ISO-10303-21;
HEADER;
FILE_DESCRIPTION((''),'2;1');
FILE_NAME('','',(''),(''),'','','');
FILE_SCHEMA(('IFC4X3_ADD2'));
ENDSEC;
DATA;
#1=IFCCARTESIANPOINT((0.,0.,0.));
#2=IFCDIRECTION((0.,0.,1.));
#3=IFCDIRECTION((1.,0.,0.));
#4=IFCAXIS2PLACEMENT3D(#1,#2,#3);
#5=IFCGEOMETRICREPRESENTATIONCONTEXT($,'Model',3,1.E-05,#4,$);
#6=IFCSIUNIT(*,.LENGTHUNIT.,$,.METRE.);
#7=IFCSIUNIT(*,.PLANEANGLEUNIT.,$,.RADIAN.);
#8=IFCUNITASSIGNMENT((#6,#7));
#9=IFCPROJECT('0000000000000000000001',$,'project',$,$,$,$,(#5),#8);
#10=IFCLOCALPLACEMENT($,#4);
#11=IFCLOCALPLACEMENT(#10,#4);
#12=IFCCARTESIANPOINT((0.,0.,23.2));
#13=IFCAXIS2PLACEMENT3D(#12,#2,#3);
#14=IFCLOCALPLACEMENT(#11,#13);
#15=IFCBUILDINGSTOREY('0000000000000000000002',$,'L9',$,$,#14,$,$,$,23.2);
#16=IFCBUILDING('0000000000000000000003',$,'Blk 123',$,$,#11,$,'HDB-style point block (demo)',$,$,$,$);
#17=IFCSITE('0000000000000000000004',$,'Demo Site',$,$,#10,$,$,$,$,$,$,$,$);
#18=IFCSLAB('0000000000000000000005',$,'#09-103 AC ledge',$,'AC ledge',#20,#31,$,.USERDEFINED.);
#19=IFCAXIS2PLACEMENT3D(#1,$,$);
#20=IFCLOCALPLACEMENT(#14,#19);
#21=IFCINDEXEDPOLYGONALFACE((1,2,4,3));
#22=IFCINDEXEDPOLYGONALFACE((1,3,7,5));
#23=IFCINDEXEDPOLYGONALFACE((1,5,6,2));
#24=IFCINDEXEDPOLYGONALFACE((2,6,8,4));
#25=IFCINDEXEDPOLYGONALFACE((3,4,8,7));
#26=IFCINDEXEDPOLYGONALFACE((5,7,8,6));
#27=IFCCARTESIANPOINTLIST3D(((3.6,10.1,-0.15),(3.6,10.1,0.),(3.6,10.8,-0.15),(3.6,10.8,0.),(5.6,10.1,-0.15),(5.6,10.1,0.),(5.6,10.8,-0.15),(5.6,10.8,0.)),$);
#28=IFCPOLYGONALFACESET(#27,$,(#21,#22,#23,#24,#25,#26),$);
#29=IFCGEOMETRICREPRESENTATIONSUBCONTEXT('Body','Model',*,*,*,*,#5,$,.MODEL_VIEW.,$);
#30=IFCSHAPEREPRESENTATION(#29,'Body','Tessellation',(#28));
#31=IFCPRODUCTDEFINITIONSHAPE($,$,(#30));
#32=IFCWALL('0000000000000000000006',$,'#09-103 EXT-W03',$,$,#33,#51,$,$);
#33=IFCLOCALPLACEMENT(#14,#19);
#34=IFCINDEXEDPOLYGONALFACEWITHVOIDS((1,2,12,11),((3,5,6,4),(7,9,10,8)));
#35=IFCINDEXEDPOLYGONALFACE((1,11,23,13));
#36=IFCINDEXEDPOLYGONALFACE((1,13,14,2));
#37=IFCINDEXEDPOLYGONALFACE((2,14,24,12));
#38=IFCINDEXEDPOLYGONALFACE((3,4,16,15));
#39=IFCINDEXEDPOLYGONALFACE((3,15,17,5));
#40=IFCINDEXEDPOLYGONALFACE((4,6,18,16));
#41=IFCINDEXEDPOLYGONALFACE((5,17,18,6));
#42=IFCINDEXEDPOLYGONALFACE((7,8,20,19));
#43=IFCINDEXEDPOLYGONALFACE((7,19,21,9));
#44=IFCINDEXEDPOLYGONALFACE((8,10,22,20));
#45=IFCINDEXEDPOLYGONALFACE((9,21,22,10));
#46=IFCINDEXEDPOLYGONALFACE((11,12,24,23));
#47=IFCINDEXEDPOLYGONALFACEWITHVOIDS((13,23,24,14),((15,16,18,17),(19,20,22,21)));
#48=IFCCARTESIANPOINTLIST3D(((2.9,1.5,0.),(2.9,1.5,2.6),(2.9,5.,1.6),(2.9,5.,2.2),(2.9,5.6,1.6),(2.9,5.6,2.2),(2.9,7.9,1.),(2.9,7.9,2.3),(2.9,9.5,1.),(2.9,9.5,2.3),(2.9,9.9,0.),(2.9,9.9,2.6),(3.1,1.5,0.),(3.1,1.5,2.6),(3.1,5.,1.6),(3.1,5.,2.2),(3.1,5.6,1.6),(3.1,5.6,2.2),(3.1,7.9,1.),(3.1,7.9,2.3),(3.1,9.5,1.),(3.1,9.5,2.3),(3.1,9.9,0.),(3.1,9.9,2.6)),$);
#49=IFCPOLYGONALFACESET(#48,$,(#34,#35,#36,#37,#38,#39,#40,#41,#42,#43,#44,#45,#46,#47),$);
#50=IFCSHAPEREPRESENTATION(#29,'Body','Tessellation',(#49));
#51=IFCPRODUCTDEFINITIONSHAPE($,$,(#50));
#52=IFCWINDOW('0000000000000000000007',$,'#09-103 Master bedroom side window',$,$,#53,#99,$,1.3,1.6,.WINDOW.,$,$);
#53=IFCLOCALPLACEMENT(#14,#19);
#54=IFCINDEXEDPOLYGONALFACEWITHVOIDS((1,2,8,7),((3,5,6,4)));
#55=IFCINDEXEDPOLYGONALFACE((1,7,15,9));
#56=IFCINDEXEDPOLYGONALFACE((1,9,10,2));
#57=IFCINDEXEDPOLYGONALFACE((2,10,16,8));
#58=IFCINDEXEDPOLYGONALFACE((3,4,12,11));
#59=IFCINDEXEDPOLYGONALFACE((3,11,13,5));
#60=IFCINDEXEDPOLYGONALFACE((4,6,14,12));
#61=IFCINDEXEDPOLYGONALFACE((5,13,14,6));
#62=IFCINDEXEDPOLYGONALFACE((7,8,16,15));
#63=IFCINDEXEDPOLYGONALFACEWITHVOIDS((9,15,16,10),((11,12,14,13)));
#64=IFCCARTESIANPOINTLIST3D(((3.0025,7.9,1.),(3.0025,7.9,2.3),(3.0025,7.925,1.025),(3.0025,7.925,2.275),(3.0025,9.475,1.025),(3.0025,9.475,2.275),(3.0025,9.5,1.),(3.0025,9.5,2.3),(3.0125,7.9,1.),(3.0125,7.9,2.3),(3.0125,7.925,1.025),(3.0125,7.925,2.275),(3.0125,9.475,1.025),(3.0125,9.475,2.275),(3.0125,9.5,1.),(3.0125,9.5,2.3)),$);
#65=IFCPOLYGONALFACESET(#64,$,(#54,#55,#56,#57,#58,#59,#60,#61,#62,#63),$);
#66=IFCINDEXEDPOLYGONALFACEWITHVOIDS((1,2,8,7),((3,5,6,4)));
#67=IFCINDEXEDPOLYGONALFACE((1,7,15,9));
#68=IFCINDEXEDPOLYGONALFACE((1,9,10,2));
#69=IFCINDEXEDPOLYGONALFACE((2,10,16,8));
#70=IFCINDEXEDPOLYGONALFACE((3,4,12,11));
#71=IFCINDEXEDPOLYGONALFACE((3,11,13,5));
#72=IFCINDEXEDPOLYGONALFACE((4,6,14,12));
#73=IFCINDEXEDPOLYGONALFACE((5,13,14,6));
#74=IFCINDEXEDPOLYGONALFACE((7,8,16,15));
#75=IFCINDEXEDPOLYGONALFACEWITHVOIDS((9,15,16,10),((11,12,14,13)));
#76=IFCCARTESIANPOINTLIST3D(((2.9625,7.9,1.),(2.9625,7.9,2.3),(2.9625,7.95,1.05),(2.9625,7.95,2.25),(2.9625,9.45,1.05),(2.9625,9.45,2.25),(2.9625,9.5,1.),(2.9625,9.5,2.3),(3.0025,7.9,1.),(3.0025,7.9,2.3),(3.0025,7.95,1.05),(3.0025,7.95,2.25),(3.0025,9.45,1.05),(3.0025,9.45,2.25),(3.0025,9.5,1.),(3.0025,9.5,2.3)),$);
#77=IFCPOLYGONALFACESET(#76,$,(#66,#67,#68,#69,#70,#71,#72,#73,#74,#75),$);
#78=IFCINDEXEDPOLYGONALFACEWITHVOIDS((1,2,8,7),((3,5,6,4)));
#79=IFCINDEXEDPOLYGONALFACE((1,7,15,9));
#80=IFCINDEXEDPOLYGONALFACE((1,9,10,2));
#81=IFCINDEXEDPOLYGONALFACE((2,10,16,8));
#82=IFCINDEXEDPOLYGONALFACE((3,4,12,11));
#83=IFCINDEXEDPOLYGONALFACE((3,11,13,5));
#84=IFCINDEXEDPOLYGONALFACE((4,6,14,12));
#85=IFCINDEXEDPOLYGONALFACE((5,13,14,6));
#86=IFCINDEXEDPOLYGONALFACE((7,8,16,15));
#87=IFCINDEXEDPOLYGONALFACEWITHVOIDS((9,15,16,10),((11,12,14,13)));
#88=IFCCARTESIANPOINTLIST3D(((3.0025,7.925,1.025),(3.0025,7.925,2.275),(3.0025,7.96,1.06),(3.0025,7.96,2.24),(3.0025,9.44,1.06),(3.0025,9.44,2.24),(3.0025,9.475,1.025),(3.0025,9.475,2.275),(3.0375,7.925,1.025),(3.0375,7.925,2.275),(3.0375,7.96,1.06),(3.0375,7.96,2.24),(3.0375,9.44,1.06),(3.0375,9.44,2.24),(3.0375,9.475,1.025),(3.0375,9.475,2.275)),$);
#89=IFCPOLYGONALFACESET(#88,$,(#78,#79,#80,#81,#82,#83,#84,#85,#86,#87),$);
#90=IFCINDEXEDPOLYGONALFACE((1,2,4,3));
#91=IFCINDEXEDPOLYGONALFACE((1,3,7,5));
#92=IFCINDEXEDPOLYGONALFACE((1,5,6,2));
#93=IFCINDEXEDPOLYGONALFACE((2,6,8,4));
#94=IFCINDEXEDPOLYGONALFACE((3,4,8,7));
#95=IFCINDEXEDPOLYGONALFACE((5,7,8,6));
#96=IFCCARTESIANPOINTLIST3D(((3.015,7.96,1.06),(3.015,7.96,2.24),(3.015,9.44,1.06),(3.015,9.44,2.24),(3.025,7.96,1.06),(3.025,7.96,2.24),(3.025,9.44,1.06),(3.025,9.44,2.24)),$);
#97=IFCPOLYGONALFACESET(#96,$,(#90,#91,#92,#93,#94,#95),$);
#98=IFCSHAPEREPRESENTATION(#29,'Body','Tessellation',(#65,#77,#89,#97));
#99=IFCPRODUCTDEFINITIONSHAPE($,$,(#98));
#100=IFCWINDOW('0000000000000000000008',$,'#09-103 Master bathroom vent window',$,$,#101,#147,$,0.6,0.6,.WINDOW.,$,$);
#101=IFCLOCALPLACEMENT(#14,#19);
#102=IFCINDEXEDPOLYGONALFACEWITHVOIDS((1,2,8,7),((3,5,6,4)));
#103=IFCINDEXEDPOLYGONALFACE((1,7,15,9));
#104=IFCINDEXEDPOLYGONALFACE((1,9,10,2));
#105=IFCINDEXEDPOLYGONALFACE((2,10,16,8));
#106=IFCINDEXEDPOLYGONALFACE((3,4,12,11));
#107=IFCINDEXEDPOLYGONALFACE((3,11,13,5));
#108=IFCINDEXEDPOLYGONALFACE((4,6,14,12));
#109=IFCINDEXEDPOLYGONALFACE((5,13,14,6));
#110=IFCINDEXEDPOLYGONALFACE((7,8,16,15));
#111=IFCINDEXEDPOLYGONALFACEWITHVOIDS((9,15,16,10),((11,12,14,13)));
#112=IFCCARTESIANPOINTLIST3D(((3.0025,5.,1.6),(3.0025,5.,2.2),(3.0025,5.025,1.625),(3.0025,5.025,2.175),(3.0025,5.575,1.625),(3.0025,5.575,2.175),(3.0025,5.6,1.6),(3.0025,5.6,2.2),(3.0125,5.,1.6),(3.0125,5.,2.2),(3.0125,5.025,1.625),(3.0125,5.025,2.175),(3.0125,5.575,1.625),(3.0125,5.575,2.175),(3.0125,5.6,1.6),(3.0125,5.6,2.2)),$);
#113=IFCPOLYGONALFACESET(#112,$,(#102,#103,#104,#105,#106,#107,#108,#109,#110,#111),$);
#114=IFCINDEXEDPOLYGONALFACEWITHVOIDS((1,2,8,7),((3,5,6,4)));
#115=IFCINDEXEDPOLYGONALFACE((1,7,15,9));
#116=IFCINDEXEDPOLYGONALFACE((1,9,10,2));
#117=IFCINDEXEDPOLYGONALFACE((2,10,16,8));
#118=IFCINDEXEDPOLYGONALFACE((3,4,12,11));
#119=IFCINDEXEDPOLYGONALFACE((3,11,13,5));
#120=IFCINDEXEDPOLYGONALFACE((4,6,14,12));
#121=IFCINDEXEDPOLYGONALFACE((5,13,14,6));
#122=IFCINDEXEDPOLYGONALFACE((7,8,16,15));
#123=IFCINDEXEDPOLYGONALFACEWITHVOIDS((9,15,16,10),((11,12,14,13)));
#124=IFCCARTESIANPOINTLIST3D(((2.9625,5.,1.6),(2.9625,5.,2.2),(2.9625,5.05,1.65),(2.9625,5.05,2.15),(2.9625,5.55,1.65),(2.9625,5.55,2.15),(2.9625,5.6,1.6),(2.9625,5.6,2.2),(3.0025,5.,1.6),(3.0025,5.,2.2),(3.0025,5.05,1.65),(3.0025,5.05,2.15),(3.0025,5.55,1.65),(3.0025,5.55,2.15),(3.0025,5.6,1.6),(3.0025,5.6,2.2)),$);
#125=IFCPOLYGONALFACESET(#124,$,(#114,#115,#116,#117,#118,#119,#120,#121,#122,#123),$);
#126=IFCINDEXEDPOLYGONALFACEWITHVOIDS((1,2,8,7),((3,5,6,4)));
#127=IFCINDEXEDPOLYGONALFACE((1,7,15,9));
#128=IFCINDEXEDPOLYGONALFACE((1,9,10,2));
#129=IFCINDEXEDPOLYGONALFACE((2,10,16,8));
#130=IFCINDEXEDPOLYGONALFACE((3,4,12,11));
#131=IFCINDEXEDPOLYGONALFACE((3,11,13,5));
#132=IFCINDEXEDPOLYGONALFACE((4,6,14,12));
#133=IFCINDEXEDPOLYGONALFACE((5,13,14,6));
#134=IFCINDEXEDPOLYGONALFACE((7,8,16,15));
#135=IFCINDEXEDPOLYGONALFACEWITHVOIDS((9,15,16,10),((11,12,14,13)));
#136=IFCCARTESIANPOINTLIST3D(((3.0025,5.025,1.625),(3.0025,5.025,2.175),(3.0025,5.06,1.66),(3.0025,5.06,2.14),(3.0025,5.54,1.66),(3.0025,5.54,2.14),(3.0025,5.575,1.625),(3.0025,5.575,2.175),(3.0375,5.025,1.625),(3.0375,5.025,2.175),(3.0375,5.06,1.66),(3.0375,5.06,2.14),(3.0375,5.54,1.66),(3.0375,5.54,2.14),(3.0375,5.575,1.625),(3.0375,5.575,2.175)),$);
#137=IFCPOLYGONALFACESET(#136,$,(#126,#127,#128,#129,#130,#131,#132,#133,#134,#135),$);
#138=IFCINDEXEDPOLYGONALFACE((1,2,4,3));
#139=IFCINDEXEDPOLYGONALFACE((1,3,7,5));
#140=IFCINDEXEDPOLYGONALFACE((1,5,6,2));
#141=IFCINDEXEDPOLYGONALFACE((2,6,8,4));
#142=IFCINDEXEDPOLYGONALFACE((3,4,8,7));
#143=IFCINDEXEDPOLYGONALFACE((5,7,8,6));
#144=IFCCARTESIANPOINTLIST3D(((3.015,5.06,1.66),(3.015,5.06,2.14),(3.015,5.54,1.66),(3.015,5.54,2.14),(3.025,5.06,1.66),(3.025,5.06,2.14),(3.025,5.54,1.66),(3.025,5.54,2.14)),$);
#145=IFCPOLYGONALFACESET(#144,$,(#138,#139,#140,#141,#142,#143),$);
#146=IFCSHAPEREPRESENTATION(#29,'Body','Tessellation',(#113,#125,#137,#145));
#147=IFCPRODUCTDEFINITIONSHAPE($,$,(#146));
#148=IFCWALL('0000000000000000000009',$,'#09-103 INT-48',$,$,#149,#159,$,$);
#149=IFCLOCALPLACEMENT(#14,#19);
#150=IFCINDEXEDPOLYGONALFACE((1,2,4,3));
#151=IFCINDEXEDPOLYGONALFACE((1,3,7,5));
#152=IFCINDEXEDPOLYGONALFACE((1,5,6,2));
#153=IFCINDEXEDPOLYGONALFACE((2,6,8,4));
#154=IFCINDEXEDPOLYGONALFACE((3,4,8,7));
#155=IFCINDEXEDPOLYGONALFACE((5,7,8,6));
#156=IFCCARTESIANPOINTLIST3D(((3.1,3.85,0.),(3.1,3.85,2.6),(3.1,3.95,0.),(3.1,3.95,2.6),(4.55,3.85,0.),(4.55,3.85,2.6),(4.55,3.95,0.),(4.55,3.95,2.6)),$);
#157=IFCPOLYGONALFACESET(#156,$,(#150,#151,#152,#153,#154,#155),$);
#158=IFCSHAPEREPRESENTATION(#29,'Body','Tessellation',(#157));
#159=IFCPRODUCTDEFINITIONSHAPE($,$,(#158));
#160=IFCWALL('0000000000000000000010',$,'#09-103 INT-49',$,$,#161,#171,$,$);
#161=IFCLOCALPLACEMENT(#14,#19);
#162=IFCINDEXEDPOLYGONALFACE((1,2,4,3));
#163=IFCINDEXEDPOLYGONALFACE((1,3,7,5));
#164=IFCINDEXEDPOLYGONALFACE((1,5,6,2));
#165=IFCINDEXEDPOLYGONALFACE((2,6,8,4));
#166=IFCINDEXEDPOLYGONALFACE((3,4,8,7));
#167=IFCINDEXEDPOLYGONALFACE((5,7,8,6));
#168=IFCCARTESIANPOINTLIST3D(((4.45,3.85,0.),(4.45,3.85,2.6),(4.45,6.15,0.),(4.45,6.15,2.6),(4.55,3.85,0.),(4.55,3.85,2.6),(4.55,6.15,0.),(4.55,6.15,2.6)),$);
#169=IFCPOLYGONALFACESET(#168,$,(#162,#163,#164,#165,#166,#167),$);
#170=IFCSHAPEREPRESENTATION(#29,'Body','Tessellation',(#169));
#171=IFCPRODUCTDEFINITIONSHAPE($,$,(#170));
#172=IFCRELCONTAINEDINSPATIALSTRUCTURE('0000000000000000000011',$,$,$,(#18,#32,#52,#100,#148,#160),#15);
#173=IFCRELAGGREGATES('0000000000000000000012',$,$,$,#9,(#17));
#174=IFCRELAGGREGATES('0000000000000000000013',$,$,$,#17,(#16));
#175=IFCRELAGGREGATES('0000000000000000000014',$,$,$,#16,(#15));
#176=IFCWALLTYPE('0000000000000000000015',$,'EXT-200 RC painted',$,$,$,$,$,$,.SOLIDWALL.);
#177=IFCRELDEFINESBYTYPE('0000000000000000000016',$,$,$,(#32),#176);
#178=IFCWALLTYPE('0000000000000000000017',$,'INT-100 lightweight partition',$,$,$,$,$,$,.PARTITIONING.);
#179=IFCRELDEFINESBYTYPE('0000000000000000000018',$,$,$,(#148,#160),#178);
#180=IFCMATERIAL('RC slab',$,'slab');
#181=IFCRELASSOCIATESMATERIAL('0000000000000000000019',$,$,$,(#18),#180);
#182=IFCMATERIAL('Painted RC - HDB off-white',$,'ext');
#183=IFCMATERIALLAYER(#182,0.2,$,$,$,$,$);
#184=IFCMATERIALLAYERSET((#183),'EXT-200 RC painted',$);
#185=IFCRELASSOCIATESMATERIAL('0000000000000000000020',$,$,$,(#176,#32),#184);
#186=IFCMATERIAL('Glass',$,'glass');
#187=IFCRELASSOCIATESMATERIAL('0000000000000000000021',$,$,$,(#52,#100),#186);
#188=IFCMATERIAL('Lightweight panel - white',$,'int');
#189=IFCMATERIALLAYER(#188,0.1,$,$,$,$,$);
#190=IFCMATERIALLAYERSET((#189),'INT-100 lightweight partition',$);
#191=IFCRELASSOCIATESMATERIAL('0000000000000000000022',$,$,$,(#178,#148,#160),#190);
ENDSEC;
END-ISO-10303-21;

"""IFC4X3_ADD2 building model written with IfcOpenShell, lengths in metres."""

from ifc_helpers import new_model, si_unit, frame, origin, origin_with_axes, place, context, subcontext, project, spatial, polyline, line, indexed_curve, outline, extrude, material, layer, layer_set, layer_usage, type_object, element, fill, save


model = new_model("IFC4X3_ADD2")

# Units and contexts
model_context = context("Model", 3, precision=1e-05, world=origin_with_axes())
body_context = subcontext(model_context, "Body", "Model", "MODEL_VIEW")
ifc_project = project(units=[si_unit("LENGTHUNIT", "METRE"), si_unit("PLANEANGLEUNIT", "RADIAN")], contexts=[model_context])

# Site, building, storey
site_placement = place(None, origin_with_axes())
site = spatial("IfcSite", under=ifc_project, at=site_placement, Name="Demo Site")
building_placement = place(site_placement, origin_with_axes())
building = spatial("IfcBuilding", under=site, at=building_placement, Name="Blk 123", LongName="HDB-style point block (demo)")
storey_placement = place(building_placement, frame((0.0, 0.0, 23.2), z_axis=(0.0, 0.0, 1.0), x_axis=(1.0, 0.0, 0.0)))
storey = spatial("IfcBuildingStorey", under=building, at=storey_placement, Name="L9", Elevation=23.2)

# Slab
ifc_material_1 = material(Name="RC slab", Category="slab")
slab_placement = place(storey_placement, frame((4.6, 10.45, -0.15), z_axis=(0.0, 0.0, 1.0), x_axis=(1.0, 0.0, 0.0)))
element("IfcSlab", 1, at=slab_placement, inside=storey, material=ifc_material_1, Name="#09-103 AC ledge", ObjectType="AC ledge", PredefinedType="USERDEFINED", context=body_context, shape_type="SweptSolid", body=[
    extrude(outline(polyline([(1.0, -0.35), (1.0, 0.35), (-1.0, 0.35), (-1.0, -0.35), (1.0, -0.35)])), origin(), (0.0, 0.0, 1.0), 0.15),
])

# Wall, openings, windows
ifc_material_2 = material(Name="Painted RC - HDB off-white", Category="ext")
ifc_layer_1 = layer(ifc_material_2, 0.2)
ifc_layer_set_1 = layer_set([ifc_layer_1], Name="EXT-200 RC painted")
ifc_layer_usage_1 = layer_usage(ifc_layer_set_1, "AXIS2", "POSITIVE", 0.0)
wall_type_1 = type_object("IfcWallType", Name="EXT-200 RC painted", PredefinedType="SOLIDWALL", material=ifc_layer_set_1)
wall_1_placement = place(storey_placement, frame((2.9, 9.9, 0.0), z_axis=(0.0, 0.0, 1.0), x_axis=(0.0, -1.0, 0.0)))
wall_1 = element("IfcWall", 2, at=wall_1_placement, inside=storey, type_object=wall_type_1, material=ifc_layer_usage_1, Name="#09-103 EXT-W03", context=body_context, shape_type="SweptSolid", body=[
    extrude(outline(indexed_curve([(0.0, 0.0), (0.0, 0.2), (8.4, 0.2), (8.4, 0.0), (0.0, 0.0)], self_intersect=False)), origin_with_axes(), (0.0, 0.0, 1.0), 2.6),
])
opening_1_placement = place(wall_1_placement, frame((0.4, -0.1, 1.0), z_axis=(0.0, 0.0, 1.0), x_axis=(1.0, 0.0, 0.0)))
opening_1 = element("IfcOpeningElement", 3, at=opening_1_placement, cuts=wall_1, context=body_context, shape_type="SweptSolid", body=[
    extrude(outline(indexed_curve([(0.0, 0.0), (0.0, 0.4), (1.6, 0.4), (1.6, 0.0), (0.0, 0.0)], self_intersect=False)), origin_with_axes(), (0.0, 0.0, 1.0), 1.3),
])
opening_2_placement = place(wall_1_placement, frame((4.3, -0.1, 1.6), z_axis=(0.0, 0.0, 1.0), x_axis=(1.0, 0.0, 0.0)))
opening_2 = element("IfcOpeningElement", 4, at=opening_2_placement, cuts=wall_1, context=body_context, shape_type="SweptSolid", body=[
    extrude(outline(indexed_curve([(0.0, 0.0), (0.0, 0.4), (0.6, 0.4), (0.6, 0.0), (0.0, 0.0)], self_intersect=False)), origin_with_axes(), (0.0, 0.0, 1.0), 0.6),
])
ifc_material_3 = material(Name="Glass", Category="glass")
window_1_placement = place(opening_1_placement, frame((0.0, 0.1125, 0.0), z_axis=(0.0, 0.0, 1.0), x_axis=(1.0, 0.0, 0.0)))
window_1 = element("IfcWindow", 5, at=window_1_placement, inside=storey, material=ifc_material_3, Name="#09-103 Master bedroom side window", OverallHeight=1.3, OverallWidth=1.6, PredefinedType="WINDOW", context=body_context, shape_type="SweptSolid", body=[
    extrude(outline(indexed_curve([(0.0, 0.0), (1.6, 0.0), (1.6, 1.3), (0.0, 1.3)], segments=[line(1, 2, 3, 4, 1)]), holes=[indexed_curve([(0.025, 0.025), (1.575, 0.025), (1.575, 1.275), (0.025, 1.275)], segments=[line(1, 2, 3, 4, 1)])]), frame((0.0, 0.09, 0.0), z_axis=(0.0, -1.0, 0.0), x_axis=(1.0, 0.0, 0.0)), (0.0, 0.0, -1.0), 0.01),
    extrude(outline(indexed_curve([(0.0, 0.0), (1.6, 0.0), (1.6, 1.3), (0.0, 1.3)], segments=[line(1, 2, 3, 4, 1)]), holes=[indexed_curve([(0.05, 0.05), (1.55, 0.05), (1.55, 1.25), (0.05, 1.25)], segments=[line(1, 2, 3, 4, 1)])]), frame((0.0, 0.05, 0.0), z_axis=(0.0, -1.0, 0.0), x_axis=(1.0, 0.0, 0.0)), (0.0, 0.0, -1.0), 0.04),
    extrude(outline(indexed_curve([(0.0, 0.0), (1.55, 0.0), (1.55, 1.25), (0.0, 1.25)], segments=[line(1, 2, 3, 4, 1)]), holes=[indexed_curve([(0.035, 0.035), (1.515, 0.035), (1.515, 1.215), (0.035, 1.215)], segments=[line(1, 2, 3, 4, 1)])]), frame((0.025, 0.09, 0.025), z_axis=(0.0, -1.0, 0.0), x_axis=(1.0, 0.0, 0.0)), (0.0, 0.0, -1.0), 0.035),
    extrude(outline(indexed_curve([(0.035, 0.035), (1.515, 0.035), (1.515, 1.215), (0.035, 1.215)], segments=[line(1, 2, 3, 4, 1)])), frame((0.025, 0.1025, 0.025), z_axis=(0.0, -1.0, 0.0), x_axis=(1.0, 0.0, 0.0)), (0.0, 0.0, -1.0), 0.01),
])
fill(opening_1, window_1)
window_2_placement = place(opening_2_placement, frame((0.0, 0.1125, 0.0), z_axis=(0.0, 0.0, 1.0), x_axis=(1.0, 0.0, 0.0)))
window_2 = element("IfcWindow", 6, at=window_2_placement, inside=storey, material=ifc_material_3, Name="#09-103 Master bathroom vent window", OverallHeight=0.6, OverallWidth=0.6, PredefinedType="WINDOW", context=body_context, shape_type="SweptSolid", body=[
    extrude(outline(indexed_curve([(0.0, 0.0), (0.6, 0.0), (0.6, 0.6), (0.0, 0.6)], segments=[line(1, 2, 3, 4, 1)]), holes=[indexed_curve([(0.025, 0.025), (0.575, 0.025), (0.575, 0.575), (0.025, 0.575)], segments=[line(1, 2, 3, 4, 1)])]), frame((0.0, 0.09, 0.0), z_axis=(0.0, -1.0, 0.0), x_axis=(1.0, 0.0, 0.0)), (0.0, 0.0, -1.0), 0.01),
    extrude(outline(indexed_curve([(0.0, 0.0), (0.6, 0.0), (0.6, 0.6), (0.0, 0.6)], segments=[line(1, 2, 3, 4, 1)]), holes=[indexed_curve([(0.05, 0.05), (0.55, 0.05), (0.55, 0.55), (0.05, 0.55)], segments=[line(1, 2, 3, 4, 1)])]), frame((0.0, 0.05, 0.0), z_axis=(0.0, -1.0, 0.0), x_axis=(1.0, 0.0, 0.0)), (0.0, 0.0, -1.0), 0.04),
    extrude(outline(indexed_curve([(0.0, 0.0), (0.55, 0.0), (0.55, 0.55), (0.0, 0.55)], segments=[line(1, 2, 3, 4, 1)]), holes=[indexed_curve([(0.035, 0.035), (0.515, 0.035), (0.515, 0.515), (0.035, 0.515)], segments=[line(1, 2, 3, 4, 1)])]), frame((0.025, 0.09, 0.025), z_axis=(0.0, -1.0, 0.0), x_axis=(1.0, 0.0, 0.0)), (0.0, 0.0, -1.0), 0.035),
    extrude(outline(indexed_curve([(0.035, 0.035), (0.515, 0.035), (0.515, 0.515), (0.035, 0.515)], segments=[line(1, 2, 3, 4, 1)])), frame((0.025, 0.1025, 0.025), z_axis=(0.0, -1.0, 0.0), x_axis=(1.0, 0.0, 0.0)), (0.0, 0.0, -1.0), 0.01),
])
fill(opening_2, window_2)

# Shared definitions
ifc_material_4 = material(Name="Lightweight panel - white", Category="int")
ifc_layer_2 = layer(ifc_material_4, 0.1)
ifc_layer_set_2 = layer_set([ifc_layer_2], Name="INT-100 lightweight partition")
ifc_layer_usage_2 = layer_usage(ifc_layer_set_2, "AXIS2", "POSITIVE", -0.05)
wall_type_2 = type_object("IfcWallType", Name="INT-100 lightweight partition", PredefinedType="PARTITIONING", material=ifc_layer_set_2)

# Walls
wall_2_placement = place(storey_placement, frame((3.1, 3.9, 0.0), z_axis=(0.0, 0.0, 1.0), x_axis=(1.0, 0.0, 0.0)))
element("IfcWall", 7, at=wall_2_placement, inside=storey, type_object=wall_type_2, material=ifc_layer_usage_2, Name="#09-103 INT-48", context=body_context, shape_type="SweptSolid", body=[
    extrude(outline(indexed_curve([(0.0, 0.0), (0.0, 0.1), (1.45, 0.1), (1.45, 0.0), (0.0, 0.0)], self_intersect=False)), frame((0.0, -0.05, 0.0), z_axis=(0.0, 0.0, 1.0), x_axis=(1.0, 0.0, 0.0)), (0.0, 0.0, 1.0), 2.6),
])
wall_3_placement = place(storey_placement, frame((4.5, 3.85, 0.0), z_axis=(0.0, 0.0, 1.0), x_axis=(0.0, 1.0, 0.0)))
element("IfcWall", 8, at=wall_3_placement, inside=storey, type_object=wall_type_2, material=ifc_layer_usage_2, Name="#09-103 INT-49", context=body_context, shape_type="SweptSolid", body=[
    extrude(outline(indexed_curve([(0.0, 0.0), (0.0, 0.1), (2.3, 0.1), (2.3, 0.0), (0.0, 0.0)], self_intersect=False)), frame((0.0, -0.05, 0.0), z_axis=(0.0, 0.0, 1.0), x_axis=(1.0, 0.0, 0.0)), (0.0, 0.0, 1.0), 2.6),
])

save(model, "model.ifc")
